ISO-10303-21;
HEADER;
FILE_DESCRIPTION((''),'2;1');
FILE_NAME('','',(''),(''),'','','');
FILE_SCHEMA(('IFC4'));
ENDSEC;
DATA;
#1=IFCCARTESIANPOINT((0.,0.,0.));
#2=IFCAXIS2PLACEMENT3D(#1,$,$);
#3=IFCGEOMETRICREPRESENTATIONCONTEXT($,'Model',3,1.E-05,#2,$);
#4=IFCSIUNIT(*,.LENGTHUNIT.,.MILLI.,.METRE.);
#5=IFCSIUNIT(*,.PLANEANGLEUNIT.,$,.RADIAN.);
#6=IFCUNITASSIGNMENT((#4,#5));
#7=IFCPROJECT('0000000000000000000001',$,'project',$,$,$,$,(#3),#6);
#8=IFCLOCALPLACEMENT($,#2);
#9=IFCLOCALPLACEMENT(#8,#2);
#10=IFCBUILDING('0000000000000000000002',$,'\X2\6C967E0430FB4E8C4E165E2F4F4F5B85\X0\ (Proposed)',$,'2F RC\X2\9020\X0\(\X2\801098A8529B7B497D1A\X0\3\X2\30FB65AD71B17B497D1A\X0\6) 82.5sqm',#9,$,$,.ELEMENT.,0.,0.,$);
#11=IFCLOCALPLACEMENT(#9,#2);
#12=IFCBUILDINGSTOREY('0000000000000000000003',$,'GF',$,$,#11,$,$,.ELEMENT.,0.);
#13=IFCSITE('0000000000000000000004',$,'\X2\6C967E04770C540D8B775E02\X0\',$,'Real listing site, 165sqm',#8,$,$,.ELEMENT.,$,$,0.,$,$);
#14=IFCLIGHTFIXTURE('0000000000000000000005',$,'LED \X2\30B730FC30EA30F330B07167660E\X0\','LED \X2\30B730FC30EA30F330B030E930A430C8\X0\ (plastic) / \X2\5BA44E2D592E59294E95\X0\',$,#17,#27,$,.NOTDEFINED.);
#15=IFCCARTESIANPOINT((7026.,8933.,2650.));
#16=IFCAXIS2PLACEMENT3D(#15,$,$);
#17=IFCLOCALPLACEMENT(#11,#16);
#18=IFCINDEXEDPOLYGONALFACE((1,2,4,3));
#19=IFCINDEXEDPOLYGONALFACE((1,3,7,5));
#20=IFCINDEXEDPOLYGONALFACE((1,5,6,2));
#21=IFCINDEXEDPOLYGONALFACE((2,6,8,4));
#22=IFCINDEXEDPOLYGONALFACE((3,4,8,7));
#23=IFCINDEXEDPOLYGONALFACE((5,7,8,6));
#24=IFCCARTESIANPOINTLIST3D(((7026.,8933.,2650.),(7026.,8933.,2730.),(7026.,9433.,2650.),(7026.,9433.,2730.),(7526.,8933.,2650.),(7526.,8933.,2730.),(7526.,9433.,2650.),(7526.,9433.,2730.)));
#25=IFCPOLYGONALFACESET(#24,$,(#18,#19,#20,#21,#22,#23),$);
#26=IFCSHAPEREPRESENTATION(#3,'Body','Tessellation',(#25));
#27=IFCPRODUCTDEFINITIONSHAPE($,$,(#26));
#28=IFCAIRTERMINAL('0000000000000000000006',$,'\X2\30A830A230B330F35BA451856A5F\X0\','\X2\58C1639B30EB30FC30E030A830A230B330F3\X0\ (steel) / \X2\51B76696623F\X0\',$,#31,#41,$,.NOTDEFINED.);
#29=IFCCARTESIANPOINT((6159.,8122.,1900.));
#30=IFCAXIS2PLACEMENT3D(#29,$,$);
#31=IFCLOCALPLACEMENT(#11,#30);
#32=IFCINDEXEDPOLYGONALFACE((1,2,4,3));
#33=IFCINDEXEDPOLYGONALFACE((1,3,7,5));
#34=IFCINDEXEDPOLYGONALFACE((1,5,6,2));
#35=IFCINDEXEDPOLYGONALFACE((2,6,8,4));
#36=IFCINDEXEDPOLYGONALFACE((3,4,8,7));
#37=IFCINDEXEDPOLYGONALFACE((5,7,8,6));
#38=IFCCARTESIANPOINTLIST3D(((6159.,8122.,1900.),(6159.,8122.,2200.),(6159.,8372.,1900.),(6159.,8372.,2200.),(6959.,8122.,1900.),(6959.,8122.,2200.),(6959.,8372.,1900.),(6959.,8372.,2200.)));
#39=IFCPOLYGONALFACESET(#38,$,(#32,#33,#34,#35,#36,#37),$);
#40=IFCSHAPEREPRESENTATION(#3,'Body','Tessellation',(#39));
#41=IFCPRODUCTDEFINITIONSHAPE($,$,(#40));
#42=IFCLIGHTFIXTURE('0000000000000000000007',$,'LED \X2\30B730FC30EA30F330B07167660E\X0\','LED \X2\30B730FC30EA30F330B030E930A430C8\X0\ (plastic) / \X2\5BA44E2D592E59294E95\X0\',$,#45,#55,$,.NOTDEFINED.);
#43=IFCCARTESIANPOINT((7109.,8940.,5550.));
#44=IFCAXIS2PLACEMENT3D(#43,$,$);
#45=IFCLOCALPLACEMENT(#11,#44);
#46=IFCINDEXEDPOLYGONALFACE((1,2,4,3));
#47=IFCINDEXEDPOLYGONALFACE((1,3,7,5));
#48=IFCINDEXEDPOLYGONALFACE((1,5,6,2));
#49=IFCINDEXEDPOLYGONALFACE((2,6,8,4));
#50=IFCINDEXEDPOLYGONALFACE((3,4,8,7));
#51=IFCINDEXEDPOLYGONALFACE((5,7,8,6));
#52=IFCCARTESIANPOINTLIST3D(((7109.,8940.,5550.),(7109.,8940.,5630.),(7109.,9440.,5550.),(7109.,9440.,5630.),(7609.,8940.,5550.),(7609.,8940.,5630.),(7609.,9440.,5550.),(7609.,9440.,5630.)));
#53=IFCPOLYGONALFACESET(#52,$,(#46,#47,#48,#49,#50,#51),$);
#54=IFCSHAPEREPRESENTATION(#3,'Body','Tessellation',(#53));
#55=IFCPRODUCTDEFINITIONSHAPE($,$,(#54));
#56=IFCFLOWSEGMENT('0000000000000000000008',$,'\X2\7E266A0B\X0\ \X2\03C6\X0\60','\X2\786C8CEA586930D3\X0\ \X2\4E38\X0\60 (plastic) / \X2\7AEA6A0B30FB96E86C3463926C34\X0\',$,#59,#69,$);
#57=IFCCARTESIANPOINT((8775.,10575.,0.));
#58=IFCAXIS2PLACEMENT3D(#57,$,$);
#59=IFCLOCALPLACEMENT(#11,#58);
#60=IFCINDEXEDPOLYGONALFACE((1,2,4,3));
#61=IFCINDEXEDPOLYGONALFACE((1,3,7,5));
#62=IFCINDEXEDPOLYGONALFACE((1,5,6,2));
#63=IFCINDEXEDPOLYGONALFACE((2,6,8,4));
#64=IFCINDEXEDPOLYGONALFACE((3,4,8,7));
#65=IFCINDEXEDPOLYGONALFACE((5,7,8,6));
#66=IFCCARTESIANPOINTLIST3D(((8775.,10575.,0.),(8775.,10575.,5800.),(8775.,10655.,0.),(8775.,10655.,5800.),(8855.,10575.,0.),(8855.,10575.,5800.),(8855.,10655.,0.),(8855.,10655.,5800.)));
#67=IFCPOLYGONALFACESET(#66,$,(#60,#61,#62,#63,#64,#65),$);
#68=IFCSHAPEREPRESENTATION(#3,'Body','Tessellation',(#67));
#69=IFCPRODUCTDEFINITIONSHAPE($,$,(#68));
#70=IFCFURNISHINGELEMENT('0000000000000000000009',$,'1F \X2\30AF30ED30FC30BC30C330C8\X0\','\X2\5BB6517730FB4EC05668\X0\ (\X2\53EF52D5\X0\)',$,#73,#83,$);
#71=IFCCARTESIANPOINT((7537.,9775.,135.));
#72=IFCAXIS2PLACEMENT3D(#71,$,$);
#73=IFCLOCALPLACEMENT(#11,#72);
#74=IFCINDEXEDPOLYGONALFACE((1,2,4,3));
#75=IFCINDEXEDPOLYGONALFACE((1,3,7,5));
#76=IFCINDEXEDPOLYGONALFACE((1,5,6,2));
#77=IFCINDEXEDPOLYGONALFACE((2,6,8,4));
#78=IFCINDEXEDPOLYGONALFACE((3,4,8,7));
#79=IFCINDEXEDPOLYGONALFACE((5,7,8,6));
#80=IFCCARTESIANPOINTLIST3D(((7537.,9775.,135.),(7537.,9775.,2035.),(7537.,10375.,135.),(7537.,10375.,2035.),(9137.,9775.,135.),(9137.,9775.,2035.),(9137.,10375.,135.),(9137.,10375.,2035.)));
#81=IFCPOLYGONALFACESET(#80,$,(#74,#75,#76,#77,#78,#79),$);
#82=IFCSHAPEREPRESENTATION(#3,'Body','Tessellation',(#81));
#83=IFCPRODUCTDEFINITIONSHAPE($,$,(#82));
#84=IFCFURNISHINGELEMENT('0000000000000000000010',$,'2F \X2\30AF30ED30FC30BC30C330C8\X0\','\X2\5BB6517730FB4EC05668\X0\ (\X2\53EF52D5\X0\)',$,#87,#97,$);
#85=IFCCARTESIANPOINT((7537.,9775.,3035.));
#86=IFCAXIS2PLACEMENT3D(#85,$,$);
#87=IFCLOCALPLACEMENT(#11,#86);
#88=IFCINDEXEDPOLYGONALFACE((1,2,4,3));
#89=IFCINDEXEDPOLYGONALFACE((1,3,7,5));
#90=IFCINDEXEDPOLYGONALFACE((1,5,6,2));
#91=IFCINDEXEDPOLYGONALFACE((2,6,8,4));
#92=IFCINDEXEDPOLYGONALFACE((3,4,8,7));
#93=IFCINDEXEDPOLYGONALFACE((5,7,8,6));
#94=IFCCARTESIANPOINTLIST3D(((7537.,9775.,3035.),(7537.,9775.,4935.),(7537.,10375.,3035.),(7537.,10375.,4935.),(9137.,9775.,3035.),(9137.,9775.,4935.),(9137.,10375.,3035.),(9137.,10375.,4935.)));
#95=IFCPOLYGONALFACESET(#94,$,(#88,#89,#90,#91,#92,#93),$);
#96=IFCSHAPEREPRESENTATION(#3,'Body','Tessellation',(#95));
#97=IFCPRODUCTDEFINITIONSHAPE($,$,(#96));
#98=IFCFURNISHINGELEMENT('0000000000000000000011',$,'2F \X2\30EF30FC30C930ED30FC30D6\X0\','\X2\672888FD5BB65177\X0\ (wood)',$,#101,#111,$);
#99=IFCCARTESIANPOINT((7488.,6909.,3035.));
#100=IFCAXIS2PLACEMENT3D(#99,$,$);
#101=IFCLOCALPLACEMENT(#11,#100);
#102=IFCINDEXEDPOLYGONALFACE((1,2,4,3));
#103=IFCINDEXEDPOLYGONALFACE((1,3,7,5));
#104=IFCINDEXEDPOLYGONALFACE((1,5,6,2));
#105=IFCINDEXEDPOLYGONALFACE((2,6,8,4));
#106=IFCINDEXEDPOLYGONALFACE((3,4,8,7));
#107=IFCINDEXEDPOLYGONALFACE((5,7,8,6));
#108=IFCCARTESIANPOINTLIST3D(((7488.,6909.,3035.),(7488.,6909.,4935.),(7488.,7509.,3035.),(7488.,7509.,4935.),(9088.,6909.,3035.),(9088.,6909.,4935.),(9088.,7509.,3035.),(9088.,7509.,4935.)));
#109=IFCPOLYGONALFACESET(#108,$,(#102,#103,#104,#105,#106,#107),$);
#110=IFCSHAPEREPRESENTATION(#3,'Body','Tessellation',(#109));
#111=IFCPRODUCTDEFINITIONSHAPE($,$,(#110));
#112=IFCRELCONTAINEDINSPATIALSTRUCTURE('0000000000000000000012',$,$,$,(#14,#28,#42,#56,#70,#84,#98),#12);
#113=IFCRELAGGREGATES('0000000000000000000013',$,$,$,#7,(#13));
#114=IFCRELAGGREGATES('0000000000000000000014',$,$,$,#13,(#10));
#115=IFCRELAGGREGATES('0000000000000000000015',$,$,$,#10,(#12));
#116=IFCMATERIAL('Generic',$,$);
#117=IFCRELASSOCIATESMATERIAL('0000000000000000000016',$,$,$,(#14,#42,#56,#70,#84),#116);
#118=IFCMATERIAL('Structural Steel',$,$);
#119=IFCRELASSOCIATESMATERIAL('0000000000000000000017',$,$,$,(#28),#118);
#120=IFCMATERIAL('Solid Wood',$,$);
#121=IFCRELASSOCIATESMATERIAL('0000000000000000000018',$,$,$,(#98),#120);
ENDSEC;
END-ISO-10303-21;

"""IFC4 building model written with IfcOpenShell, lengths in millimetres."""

from ifc_helpers import new_model, si_unit, frame, frame_2d, origin, place, context, project, spatial, rectangle, extrude, material, element, save


model = new_model("IFC4")

# Units and contexts
model_context = context("Model", 3, precision=1e-05, world=origin())
ifc_project = project(units=[si_unit("LENGTHUNIT", "METRE", prefix="MILLI"), si_unit("PLANEANGLEUNIT", "RADIAN")], contexts=[model_context])

# Site, building, storey
site_placement = place(None, origin())
site = spatial("IfcSite", under=ifc_project, at=site_placement, Name="沖縄県名護市", ObjectType="Real listing site, 165sqm", CompositionType="ELEMENT", RefElevation=0.0)
building_placement = place(site_placement, origin())
building = spatial("IfcBuilding", under=site, at=building_placement, Name="沖縄・二世帯住宅 (Proposed)", ObjectType="2F RC造(耐風力等級3・断熱等級6) 82.5sqm", CompositionType="ELEMENT", ElevationOfRefHeight=0.0, ElevationOfTerrain=0.0)
storey_placement = place(building_placement, origin())
storey = spatial("IfcBuildingStorey", under=building, at=storey_placement, Name="GF", CompositionType="ELEMENT", Elevation=0.0)

# Shared definitions
ifc_material_1 = material(Name="Solid Wood")

# Shared definitions
ifc_material_2 = material(Name="Structural Steel")

# Shared definitions
ifc_material_3 = material(Name="Generic")

# Light fixture
light_fixture_1_placement = place(storey_placement, frame((7026.0, 8933.0, 2650.0)))
element("IfcLightFixture", 1, at=light_fixture_1_placement, inside=storey, material=ifc_material_3, Name="LED シーリング照明", Description="LED シーリングライト (plastic) / 室中央天井", PredefinedType="NOTDEFINED", context=model_context, shape_type="SweptSolid", body=[
    extrude(rectangle(XDim=500.0, YDim=500.0, at=frame_2d((250.0, 250.0))), frame((7026.0, 8933.0, 2650.0)), (0.0, 0.0, 1.0), 80.0),
])

# Air terminal
air_terminal_placement = place(storey_placement, frame((6159.0, 8122.0, 1900.0)))
element("IfcAirTerminal", 2, at=air_terminal_placement, inside=storey, material=ifc_material_2, Name="エアコン室内機", Description="壁掛ルームエアコン (steel) / 冷暖房", PredefinedType="NOTDEFINED", context=model_context, shape_type="SweptSolid", body=[
    extrude(rectangle(XDim=800.0, YDim=250.0, at=frame_2d((400.0, 125.0))), frame((6159.0, 8122.0, 1900.0)), (0.0, 0.0, 1.0), 300.0),
])

# Light fixture
light_fixture_2_placement = place(storey_placement, frame((7109.0, 8940.0, 5550.0)))
element("IfcLightFixture", 3, at=light_fixture_2_placement, inside=storey, material=ifc_material_3, Name="LED シーリング照明", Description="LED シーリングライト (plastic) / 室中央天井", PredefinedType="NOTDEFINED", context=model_context, shape_type="SweptSolid", body=[
    extrude(rectangle(XDim=500.0, YDim=500.0, at=frame_2d((250.0, 250.0))), frame((7109.0, 8940.0, 5550.0)), (0.0, 0.0, 1.0), 80.0),
])

# Flow segment
flow_segment_placement = place(storey_placement, frame((8775.0, 10575.0, 0.0)))
element("IfcFlowSegment", 4, at=flow_segment_placement, inside=storey, material=ifc_material_3, Name="縦樋 φ60", Description="硬質塩ビ 丸60 (plastic) / 竪樋・雨水排水", context=model_context, shape_type="SweptSolid", body=[
    extrude(rectangle(XDim=80.0, YDim=80.0, at=frame_2d((40.0, 40.0))), frame((8775.0, 10575.0, 0.0)), (0.0, 0.0, 1.0), 5800.0),
])

# Furnishing elements
furnishing_1_placement = place(storey_placement, frame((7537.0, 9775.0, 135.0)))
element("IfcFurnishingElement", 5, at=furnishing_1_placement, inside=storey, material=ifc_material_3, Name="1F クローゼット", Description="家具・什器 (可動)", context=model_context, shape_type="SweptSolid", body=[
    extrude(rectangle(XDim=1600.0, YDim=600.0, at=frame_2d((800.0, 300.0))), frame((7537.0, 9775.0, 135.0)), (0.0, 0.0, 1.0), 1900.0),
])
furnishing_2_placement = place(storey_placement, frame((7537.0, 9775.0, 3035.0)))
element("IfcFurnishingElement", 6, at=furnishing_2_placement, inside=storey, material=ifc_material_3, Name="2F クローゼット", Description="家具・什器 (可動)", context=model_context, shape_type="SweptSolid", body=[
    extrude(rectangle(XDim=1600.0, YDim=600.0, at=frame_2d((800.0, 300.0))), frame((7537.0, 9775.0, 3035.0)), (0.0, 0.0, 1.0), 1900.0),
])
furnishing_3_placement = place(storey_placement, frame((7488.0, 6909.0, 3035.0)))
element("IfcFurnishingElement", 7, at=furnishing_3_placement, inside=storey, material=ifc_material_1, Name="2F ワードローブ", Description="木製家具 (wood)", context=model_context, shape_type="SweptSolid", body=[
    extrude(rectangle(XDim=1600.0, YDim=600.0, at=frame_2d((800.0, 300.0))), frame((7488.0, 6909.0, 3035.0)), (0.0, 0.0, 1.0), 1900.0),
])

save(model, "model.ifc")
